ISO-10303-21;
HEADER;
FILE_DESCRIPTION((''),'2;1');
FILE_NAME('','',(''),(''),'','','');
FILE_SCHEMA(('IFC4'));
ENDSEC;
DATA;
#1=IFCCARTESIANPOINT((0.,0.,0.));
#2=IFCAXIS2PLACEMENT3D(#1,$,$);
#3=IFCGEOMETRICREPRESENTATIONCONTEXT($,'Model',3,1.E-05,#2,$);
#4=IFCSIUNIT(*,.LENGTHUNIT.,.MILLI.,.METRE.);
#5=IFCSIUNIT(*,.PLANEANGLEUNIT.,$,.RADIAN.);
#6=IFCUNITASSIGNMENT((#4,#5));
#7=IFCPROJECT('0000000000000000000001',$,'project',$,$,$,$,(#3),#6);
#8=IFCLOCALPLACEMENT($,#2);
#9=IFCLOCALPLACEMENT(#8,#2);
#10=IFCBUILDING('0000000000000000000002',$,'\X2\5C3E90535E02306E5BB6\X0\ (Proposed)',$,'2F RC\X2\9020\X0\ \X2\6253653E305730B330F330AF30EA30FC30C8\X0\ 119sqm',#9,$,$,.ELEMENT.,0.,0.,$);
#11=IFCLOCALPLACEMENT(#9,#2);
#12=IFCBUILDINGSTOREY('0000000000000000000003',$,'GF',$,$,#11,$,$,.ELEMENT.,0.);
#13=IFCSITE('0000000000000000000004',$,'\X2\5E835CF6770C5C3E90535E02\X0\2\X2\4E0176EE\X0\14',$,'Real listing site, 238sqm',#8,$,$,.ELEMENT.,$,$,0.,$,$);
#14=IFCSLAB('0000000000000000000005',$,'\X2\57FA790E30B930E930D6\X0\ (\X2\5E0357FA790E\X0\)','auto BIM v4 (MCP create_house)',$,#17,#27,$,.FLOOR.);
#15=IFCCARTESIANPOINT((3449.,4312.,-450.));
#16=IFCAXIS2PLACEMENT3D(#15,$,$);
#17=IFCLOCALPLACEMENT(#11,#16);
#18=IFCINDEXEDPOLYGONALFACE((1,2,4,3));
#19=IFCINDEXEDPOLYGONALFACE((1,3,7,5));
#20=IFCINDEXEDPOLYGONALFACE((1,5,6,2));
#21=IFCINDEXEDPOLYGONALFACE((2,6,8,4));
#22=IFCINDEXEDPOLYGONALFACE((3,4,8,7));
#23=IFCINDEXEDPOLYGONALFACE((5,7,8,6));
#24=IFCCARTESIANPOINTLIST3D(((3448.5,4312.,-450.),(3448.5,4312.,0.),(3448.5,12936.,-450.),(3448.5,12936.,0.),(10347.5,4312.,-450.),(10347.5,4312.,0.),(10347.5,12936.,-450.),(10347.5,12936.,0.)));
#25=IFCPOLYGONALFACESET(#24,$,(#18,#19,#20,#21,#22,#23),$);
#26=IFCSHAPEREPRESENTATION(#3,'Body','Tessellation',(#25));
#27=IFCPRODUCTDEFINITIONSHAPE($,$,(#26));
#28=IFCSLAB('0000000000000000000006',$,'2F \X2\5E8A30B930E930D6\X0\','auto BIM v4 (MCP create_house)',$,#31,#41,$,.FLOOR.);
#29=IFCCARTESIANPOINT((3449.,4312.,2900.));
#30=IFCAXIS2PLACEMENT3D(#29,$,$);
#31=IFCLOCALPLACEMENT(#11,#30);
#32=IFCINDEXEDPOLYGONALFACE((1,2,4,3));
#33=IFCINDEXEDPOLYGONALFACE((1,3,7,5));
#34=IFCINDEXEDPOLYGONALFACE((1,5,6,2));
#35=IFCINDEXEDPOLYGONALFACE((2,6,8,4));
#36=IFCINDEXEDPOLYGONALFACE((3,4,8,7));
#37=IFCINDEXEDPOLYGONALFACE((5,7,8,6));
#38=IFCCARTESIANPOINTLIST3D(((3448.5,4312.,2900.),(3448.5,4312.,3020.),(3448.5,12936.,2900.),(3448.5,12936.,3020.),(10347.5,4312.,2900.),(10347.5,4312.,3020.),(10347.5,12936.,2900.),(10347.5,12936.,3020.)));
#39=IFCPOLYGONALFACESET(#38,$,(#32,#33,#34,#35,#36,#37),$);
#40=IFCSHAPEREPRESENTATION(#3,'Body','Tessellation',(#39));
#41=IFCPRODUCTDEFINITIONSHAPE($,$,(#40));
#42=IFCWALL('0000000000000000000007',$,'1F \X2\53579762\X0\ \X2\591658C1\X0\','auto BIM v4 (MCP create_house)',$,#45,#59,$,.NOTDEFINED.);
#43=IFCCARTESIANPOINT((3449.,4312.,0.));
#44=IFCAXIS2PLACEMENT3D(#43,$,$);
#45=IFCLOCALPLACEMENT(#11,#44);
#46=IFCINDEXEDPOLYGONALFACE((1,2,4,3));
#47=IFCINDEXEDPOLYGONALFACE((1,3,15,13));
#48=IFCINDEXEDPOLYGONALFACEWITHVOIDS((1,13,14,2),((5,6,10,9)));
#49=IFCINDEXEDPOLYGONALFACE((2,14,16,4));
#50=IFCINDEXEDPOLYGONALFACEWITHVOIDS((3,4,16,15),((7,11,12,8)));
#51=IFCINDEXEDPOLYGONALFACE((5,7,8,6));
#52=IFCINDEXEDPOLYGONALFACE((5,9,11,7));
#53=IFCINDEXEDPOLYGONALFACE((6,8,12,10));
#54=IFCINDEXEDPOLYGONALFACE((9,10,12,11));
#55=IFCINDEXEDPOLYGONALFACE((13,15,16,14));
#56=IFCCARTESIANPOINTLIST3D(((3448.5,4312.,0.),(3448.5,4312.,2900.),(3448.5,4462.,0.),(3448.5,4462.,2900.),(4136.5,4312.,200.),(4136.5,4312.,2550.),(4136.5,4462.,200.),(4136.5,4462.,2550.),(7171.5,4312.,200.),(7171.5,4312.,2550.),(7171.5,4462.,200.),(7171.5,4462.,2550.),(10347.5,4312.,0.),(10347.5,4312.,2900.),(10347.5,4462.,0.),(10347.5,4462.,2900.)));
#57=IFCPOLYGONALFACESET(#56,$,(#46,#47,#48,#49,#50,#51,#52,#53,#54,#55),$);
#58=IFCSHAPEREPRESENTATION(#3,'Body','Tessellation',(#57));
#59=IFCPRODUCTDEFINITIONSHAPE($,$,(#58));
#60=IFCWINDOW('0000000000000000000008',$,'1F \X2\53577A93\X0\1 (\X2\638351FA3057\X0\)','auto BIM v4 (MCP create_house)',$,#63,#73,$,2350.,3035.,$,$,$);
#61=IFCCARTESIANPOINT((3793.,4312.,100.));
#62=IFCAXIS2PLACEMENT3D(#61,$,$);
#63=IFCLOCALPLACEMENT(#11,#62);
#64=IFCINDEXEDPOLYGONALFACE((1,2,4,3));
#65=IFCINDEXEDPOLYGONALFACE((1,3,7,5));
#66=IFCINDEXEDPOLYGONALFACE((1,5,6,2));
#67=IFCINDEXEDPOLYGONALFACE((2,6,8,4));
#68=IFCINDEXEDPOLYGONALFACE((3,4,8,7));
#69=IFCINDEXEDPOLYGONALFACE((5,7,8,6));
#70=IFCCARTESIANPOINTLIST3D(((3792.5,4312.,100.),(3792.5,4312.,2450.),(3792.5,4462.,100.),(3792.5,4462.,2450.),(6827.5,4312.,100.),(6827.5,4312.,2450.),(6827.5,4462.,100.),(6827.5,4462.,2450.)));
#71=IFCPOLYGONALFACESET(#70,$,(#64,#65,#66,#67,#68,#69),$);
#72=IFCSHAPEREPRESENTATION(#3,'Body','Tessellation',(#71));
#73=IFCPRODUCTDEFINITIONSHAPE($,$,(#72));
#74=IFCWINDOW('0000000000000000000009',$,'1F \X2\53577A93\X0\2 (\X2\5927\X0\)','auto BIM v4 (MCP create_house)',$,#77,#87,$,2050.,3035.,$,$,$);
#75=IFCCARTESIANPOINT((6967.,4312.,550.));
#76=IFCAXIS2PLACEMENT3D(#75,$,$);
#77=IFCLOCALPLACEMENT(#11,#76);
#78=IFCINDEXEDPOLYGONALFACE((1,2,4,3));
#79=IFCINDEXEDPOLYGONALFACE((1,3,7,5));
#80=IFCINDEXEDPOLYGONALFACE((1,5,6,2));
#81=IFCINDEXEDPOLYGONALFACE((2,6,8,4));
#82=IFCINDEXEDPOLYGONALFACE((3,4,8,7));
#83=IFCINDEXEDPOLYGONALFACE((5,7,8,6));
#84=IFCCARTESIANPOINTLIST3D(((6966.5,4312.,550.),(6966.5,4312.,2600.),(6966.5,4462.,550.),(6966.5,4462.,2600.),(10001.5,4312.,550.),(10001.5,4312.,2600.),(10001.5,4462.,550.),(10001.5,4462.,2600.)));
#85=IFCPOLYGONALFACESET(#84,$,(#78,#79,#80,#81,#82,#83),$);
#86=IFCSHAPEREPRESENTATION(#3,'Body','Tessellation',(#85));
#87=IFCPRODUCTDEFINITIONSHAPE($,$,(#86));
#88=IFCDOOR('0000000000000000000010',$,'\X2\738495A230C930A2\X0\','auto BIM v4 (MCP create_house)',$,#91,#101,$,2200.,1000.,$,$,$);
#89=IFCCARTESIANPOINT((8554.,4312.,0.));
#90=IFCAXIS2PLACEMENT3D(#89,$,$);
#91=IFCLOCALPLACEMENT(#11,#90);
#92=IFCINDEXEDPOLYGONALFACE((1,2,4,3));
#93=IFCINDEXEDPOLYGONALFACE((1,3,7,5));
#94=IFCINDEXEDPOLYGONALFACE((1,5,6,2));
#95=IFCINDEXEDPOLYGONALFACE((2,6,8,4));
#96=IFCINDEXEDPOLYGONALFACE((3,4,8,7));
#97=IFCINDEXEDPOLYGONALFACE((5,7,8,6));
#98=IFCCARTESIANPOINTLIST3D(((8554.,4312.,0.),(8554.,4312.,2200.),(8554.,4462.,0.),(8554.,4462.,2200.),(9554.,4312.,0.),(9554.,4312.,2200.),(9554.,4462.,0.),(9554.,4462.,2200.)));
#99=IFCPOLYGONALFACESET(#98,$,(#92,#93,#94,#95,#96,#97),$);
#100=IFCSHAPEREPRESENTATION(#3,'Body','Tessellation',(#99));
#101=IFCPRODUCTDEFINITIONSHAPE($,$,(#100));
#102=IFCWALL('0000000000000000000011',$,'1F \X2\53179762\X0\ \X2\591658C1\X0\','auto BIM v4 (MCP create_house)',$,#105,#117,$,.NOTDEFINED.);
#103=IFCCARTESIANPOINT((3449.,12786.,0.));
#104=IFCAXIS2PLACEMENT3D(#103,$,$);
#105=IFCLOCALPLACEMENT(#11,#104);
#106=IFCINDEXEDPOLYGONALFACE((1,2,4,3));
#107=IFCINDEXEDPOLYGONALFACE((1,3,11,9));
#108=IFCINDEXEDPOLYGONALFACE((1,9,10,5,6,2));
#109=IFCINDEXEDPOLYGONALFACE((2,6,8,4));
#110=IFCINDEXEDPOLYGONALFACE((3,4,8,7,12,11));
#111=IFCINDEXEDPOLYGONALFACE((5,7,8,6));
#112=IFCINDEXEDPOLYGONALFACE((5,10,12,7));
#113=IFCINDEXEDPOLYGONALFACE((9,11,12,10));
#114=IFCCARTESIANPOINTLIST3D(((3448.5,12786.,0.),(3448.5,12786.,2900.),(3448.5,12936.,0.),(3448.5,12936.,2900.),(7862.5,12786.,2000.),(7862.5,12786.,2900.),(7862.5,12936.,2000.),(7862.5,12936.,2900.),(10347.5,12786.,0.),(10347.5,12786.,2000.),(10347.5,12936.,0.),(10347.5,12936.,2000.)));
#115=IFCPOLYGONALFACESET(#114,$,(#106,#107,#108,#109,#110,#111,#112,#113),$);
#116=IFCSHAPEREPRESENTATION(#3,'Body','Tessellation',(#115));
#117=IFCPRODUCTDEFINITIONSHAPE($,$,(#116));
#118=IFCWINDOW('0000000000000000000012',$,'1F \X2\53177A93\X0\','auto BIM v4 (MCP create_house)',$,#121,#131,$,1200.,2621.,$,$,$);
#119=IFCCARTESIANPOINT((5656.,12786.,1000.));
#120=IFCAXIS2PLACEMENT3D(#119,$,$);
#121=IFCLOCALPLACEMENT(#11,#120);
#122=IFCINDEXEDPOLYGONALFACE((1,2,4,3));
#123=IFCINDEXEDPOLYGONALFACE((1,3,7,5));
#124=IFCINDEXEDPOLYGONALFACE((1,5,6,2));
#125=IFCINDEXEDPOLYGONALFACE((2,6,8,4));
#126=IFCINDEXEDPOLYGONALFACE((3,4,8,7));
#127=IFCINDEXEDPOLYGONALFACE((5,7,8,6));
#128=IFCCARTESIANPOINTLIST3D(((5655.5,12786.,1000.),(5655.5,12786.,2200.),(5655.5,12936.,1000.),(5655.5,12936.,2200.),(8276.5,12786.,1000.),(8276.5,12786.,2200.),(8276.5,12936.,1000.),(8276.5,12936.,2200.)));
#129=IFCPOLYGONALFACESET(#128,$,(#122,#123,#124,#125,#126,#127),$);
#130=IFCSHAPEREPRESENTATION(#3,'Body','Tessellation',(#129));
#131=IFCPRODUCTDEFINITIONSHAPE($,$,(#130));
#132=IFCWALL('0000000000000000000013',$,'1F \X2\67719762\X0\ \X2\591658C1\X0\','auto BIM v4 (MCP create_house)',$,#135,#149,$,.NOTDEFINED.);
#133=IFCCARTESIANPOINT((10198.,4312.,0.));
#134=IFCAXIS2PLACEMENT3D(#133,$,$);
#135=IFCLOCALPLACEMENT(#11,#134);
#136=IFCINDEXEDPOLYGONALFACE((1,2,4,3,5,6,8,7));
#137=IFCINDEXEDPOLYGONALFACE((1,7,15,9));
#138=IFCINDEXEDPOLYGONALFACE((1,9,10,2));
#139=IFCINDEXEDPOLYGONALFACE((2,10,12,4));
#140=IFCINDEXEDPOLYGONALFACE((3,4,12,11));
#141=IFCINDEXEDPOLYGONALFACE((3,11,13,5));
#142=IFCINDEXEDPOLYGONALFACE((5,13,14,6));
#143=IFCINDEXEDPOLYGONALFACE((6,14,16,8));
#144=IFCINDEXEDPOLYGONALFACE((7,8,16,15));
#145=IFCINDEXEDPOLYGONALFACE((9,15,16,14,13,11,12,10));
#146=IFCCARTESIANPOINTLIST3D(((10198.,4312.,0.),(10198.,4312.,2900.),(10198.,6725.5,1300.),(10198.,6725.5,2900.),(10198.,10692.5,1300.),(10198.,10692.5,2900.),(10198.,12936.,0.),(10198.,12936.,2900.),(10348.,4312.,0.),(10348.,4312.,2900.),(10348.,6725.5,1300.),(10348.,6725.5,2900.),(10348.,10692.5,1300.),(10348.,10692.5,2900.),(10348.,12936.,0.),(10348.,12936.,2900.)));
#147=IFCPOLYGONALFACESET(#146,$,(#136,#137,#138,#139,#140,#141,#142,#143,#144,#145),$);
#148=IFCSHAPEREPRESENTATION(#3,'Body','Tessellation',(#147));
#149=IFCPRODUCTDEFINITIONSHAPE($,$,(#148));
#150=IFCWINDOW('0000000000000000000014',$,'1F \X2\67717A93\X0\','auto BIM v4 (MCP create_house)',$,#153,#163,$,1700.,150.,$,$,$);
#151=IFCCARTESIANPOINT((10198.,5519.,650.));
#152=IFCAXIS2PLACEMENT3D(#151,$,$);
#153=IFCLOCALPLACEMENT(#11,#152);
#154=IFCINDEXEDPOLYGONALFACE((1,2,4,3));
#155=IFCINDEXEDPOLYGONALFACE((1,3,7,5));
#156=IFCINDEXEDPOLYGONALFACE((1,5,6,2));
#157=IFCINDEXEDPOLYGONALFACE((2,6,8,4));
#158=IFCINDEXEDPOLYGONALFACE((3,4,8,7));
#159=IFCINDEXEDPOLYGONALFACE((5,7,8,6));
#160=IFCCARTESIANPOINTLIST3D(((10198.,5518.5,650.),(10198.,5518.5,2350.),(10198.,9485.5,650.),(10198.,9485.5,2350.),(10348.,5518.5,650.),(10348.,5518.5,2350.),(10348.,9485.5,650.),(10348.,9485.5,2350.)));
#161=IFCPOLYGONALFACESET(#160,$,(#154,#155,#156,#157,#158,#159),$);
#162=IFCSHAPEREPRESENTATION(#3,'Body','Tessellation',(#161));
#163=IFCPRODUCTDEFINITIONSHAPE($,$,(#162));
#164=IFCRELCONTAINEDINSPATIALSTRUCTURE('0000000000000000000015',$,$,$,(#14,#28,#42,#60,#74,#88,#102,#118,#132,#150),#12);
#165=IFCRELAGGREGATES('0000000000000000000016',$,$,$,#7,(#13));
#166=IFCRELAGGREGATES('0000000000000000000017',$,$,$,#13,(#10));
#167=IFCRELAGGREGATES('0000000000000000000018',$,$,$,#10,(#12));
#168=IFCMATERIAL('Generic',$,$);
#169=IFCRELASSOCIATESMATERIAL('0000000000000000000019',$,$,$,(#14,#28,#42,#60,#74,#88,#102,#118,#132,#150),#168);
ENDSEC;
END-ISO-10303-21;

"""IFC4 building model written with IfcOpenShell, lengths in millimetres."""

from ifc_helpers import new_model, si_unit, frame, frame_2d, origin, place, context, project, spatial, rectangle, extrude, material, element, fill, save


model = new_model("IFC4")

# Units and contexts
model_context = context("Model", 3, precision=1e-05, world=origin())
ifc_project = project(units=[si_unit("LENGTHUNIT", "METRE", prefix="MILLI"), si_unit("PLANEANGLEUNIT", "RADIAN")], contexts=[model_context])

# Site, building, storey
site_placement = place(None, origin())
site = spatial("IfcSite", under=ifc_project, at=site_placement, Name="広島県尾道市2丁目14", ObjectType="Real listing site, 238sqm", CompositionType="ELEMENT", RefElevation=0.0)
building_placement = place(site_placement, origin())
building = spatial("IfcBuilding", under=site, at=building_placement, Name="尾道市の家 (Proposed)", ObjectType="2F RC造 打放しコンクリート 119sqm", CompositionType="ELEMENT", ElevationOfRefHeight=0.0, ElevationOfTerrain=0.0)
storey_placement = place(building_placement, origin())
storey = spatial("IfcBuildingStorey", under=building, at=storey_placement, Name="GF", CompositionType="ELEMENT", Elevation=0.0)

# Slabs
ifc_material = material(Name="Generic")
slab_1_placement = place(storey_placement, frame((3449.0, 4312.0, -450.0)))
element("IfcSlab", 1, at=slab_1_placement, inside=storey, material=ifc_material, Name="基礎スラブ (布基礎)", Description="auto BIM v4 (MCP create_house)", PredefinedType="FLOOR", context=model_context, shape_type="SweptSolid", body=[
    extrude(rectangle(XDim=6899.0, YDim=8624.0, at=frame_2d((3449.0, 4312.0))), frame((3449.0, 4312.0, -450.0)), (0.0, 0.0, 1.0), 450.0),
])
slab_2_placement = place(storey_placement, frame((3449.0, 4312.0, 2900.0)))
element("IfcSlab", 2, at=slab_2_placement, inside=storey, material=ifc_material, Name="2F 床スラブ", Description="auto BIM v4 (MCP create_house)", PredefinedType="FLOOR", context=model_context, shape_type="SweptSolid", body=[
    extrude(rectangle(XDim=6899.0, YDim=8624.0, at=frame_2d((3449.0, 4312.0))), frame((3449.0, 4312.0, 2900.0)), (0.0, 0.0, 1.0), 120.0),
])

# Wall, openings, windows, door
wall_1_placement = place(storey_placement, frame((3449.0, 4312.0, 0.0)))
wall_1 = element("IfcWall", 3, at=wall_1_placement, inside=storey, material=ifc_material, Name="1F 南面 外壁", Description="auto BIM v4 (MCP create_house)", PredefinedType="NOTDEFINED", context=model_context, shape_type="SweptSolid", body=[
    extrude(rectangle(XDim=6899.0, YDim=150.0, at=frame_2d((3449.0, 75.0))), frame((3449.0, 4312.0, 0.0)), (0.0, 0.0, 1.0), 2900.0),
])
opening_1_placement = place(storey_placement, frame((3793.0, 4312.0, 100.0)))
opening_1 = element("IfcOpeningElement", 4, at=opening_1_placement, cuts=wall_1, PredefinedType="NOTDEFINED", context=model_context, shape_type="SweptSolid", body=[
    extrude(rectangle(XDim=3035.0, YDim=150.0, at=frame_2d((1517.0, 75.0))), frame((3793.0, 4312.0, 100.0)), (0.0, 0.0, 1.0), 2350.0),
])
opening_2_placement = place(storey_placement, frame((6967.0, 4312.0, 550.0)))
opening_2 = element("IfcOpeningElement", 5, at=opening_2_placement, cuts=wall_1, PredefinedType="NOTDEFINED", context=model_context, shape_type="SweptSolid", body=[
    extrude(rectangle(XDim=3035.0, YDim=150.0, at=frame_2d((1517.0, 75.0))), frame((6967.0, 4312.0, 550.0)), (0.0, 0.0, 1.0), 2050.0),
])
opening_3_placement = place(storey_placement, frame((8554.0, 4312.0, 0.0)))
opening_3 = element("IfcOpeningElement", 6, at=opening_3_placement, cuts=wall_1, PredefinedType="NOTDEFINED", context=model_context, shape_type="SweptSolid", body=[
    extrude(rectangle(XDim=1000.0, YDim=150.0, at=frame_2d((500.0, 75.0))), frame((8554.0, 4312.0, 0.0)), (0.0, 0.0, 1.0), 2200.0),
])
window_1_placement = place(storey_placement, frame((3793.0, 4312.0, 100.0)))
window_1 = element("IfcWindow", 7, at=window_1_placement, inside=storey, material=ifc_material, Name="1F 南窓1 (掃出し)", Description="auto BIM v4 (MCP create_house)", OverallHeight=2350.0, OverallWidth=3035.0, context=model_context, shape_type="SweptSolid", body=[
    extrude(rectangle(XDim=3035.0, YDim=150.0, at=frame_2d((1517.0, 75.0))), frame((3793.0, 4312.0, 100.0)), (0.0, 0.0, 1.0), 2350.0),
])
fill(opening_1, window_1)
window_2_placement = place(storey_placement, frame((6967.0, 4312.0, 550.0)))
window_2 = element("IfcWindow", 8, at=window_2_placement, inside=storey, material=ifc_material, Name="1F 南窓2 (大)", Description="auto BIM v4 (MCP create_house)", OverallHeight=2050.0, OverallWidth=3035.0, context=model_context, shape_type="SweptSolid", body=[
    extrude(rectangle(XDim=3035.0, YDim=150.0, at=frame_2d((1517.0, 75.0))), frame((6967.0, 4312.0, 550.0)), (0.0, 0.0, 1.0), 2050.0),
])
fill(opening_2, window_2)
door_1_placement = place(storey_placement, frame((8554.0, 4312.0, 0.0)))
door_1 = element("IfcDoor", 9, at=door_1_placement, inside=storey, material=ifc_material, Name="玄関ドア", Description="auto BIM v4 (MCP create_house)", OverallHeight=2200.0, OverallWidth=1000.0, context=model_context, shape_type="SweptSolid", body=[
    extrude(rectangle(XDim=1000.0, YDim=150.0, at=frame_2d((500.0, 75.0))), frame((8554.0, 4312.0, 0.0)), (0.0, 0.0, 1.0), 2200.0),
])
fill(opening_3, door_1)

# Walls, openings, windows
wall_2_placement = place(storey_placement, frame((3449.0, 12786.0, 0.0)))
wall_2 = element("IfcWall", 10, at=wall_2_placement, inside=storey, material=ifc_material, Name="1F 北面 外壁", Description="auto BIM v4 (MCP create_house)", PredefinedType="NOTDEFINED", context=model_context, shape_type="SweptSolid", body=[
    extrude(rectangle(XDim=6899.0, YDim=150.0, at=frame_2d((3449.0, 75.0))), frame((3449.0, 12786.0, 0.0)), (0.0, 0.0, 1.0), 2900.0),
])
opening_4_placement = place(storey_placement, frame((5656.0, 12786.0, 1000.0)))
opening_4 = element("IfcOpeningElement", 11, at=opening_4_placement, cuts=wall_2, PredefinedType="NOTDEFINED", context=model_context, shape_type="SweptSolid", body=[
    extrude(rectangle(XDim=2621.0, YDim=150.0, at=frame_2d((1310.0, 75.0))), frame((5656.0, 12786.0, 1000.0)), (0.0, 0.0, 1.0), 1200.0),
])
window_3_placement = place(storey_placement, frame((5656.0, 12786.0, 1000.0)))
window_3 = element("IfcWindow", 12, at=window_3_placement, inside=storey, material=ifc_material, Name="1F 北窓", Description="auto BIM v4 (MCP create_house)", OverallHeight=1200.0, OverallWidth=2621.0, context=model_context, shape_type="SweptSolid", body=[
    extrude(rectangle(XDim=2621.0, YDim=150.0, at=frame_2d((1310.0, 75.0))), frame((5656.0, 12786.0, 1000.0)), (0.0, 0.0, 1.0), 1200.0),
])
fill(opening_4, window_3)
wall_3_placement = place(storey_placement, frame((10198.0, 4312.0, 0.0)))
wall_3 = element("IfcWall", 13, at=wall_3_placement, inside=storey, material=ifc_material, Name="1F 東面 外壁", Description="auto BIM v4 (MCP create_house)", PredefinedType="NOTDEFINED", context=model_context, shape_type="SweptSolid", body=[
    extrude(rectangle(XDim=150.0, YDim=8624.0, at=frame_2d((75.0, 4312.0))), frame((10198.0, 4312.0, 0.0)), (0.0, 0.0, 1.0), 2900.0),
])
opening_5_placement = place(storey_placement, frame((10198.0, 5519.0, 650.0)))
opening_5 = element("IfcOpeningElement", 14, at=opening_5_placement, cuts=wall_3, PredefinedType="NOTDEFINED", context=model_context, shape_type="SweptSolid", body=[
    extrude(rectangle(XDim=150.0, YDim=3967.0, at=frame_2d((75.0, 1983.0))), frame((10198.0, 5519.0, 650.0)), (0.0, 0.0, 1.0), 1700.0),
])
window_4_placement = place(storey_placement, frame((10198.0, 5519.0, 650.0)))
window_4 = element("IfcWindow", 15, at=window_4_placement, inside=storey, material=ifc_material, Name="1F 東窓", Description="auto BIM v4 (MCP create_house)", OverallHeight=1700.0, OverallWidth=150.0, context=model_context, shape_type="SweptSolid", body=[
    extrude(rectangle(XDim=150.0, YDim=3967.0, at=frame_2d((75.0, 1983.0))), frame((10198.0, 5519.0, 650.0)), (0.0, 0.0, 1.0), 1700.0),
])
fill(opening_5, window_4)

save(model, "model.ifc")
